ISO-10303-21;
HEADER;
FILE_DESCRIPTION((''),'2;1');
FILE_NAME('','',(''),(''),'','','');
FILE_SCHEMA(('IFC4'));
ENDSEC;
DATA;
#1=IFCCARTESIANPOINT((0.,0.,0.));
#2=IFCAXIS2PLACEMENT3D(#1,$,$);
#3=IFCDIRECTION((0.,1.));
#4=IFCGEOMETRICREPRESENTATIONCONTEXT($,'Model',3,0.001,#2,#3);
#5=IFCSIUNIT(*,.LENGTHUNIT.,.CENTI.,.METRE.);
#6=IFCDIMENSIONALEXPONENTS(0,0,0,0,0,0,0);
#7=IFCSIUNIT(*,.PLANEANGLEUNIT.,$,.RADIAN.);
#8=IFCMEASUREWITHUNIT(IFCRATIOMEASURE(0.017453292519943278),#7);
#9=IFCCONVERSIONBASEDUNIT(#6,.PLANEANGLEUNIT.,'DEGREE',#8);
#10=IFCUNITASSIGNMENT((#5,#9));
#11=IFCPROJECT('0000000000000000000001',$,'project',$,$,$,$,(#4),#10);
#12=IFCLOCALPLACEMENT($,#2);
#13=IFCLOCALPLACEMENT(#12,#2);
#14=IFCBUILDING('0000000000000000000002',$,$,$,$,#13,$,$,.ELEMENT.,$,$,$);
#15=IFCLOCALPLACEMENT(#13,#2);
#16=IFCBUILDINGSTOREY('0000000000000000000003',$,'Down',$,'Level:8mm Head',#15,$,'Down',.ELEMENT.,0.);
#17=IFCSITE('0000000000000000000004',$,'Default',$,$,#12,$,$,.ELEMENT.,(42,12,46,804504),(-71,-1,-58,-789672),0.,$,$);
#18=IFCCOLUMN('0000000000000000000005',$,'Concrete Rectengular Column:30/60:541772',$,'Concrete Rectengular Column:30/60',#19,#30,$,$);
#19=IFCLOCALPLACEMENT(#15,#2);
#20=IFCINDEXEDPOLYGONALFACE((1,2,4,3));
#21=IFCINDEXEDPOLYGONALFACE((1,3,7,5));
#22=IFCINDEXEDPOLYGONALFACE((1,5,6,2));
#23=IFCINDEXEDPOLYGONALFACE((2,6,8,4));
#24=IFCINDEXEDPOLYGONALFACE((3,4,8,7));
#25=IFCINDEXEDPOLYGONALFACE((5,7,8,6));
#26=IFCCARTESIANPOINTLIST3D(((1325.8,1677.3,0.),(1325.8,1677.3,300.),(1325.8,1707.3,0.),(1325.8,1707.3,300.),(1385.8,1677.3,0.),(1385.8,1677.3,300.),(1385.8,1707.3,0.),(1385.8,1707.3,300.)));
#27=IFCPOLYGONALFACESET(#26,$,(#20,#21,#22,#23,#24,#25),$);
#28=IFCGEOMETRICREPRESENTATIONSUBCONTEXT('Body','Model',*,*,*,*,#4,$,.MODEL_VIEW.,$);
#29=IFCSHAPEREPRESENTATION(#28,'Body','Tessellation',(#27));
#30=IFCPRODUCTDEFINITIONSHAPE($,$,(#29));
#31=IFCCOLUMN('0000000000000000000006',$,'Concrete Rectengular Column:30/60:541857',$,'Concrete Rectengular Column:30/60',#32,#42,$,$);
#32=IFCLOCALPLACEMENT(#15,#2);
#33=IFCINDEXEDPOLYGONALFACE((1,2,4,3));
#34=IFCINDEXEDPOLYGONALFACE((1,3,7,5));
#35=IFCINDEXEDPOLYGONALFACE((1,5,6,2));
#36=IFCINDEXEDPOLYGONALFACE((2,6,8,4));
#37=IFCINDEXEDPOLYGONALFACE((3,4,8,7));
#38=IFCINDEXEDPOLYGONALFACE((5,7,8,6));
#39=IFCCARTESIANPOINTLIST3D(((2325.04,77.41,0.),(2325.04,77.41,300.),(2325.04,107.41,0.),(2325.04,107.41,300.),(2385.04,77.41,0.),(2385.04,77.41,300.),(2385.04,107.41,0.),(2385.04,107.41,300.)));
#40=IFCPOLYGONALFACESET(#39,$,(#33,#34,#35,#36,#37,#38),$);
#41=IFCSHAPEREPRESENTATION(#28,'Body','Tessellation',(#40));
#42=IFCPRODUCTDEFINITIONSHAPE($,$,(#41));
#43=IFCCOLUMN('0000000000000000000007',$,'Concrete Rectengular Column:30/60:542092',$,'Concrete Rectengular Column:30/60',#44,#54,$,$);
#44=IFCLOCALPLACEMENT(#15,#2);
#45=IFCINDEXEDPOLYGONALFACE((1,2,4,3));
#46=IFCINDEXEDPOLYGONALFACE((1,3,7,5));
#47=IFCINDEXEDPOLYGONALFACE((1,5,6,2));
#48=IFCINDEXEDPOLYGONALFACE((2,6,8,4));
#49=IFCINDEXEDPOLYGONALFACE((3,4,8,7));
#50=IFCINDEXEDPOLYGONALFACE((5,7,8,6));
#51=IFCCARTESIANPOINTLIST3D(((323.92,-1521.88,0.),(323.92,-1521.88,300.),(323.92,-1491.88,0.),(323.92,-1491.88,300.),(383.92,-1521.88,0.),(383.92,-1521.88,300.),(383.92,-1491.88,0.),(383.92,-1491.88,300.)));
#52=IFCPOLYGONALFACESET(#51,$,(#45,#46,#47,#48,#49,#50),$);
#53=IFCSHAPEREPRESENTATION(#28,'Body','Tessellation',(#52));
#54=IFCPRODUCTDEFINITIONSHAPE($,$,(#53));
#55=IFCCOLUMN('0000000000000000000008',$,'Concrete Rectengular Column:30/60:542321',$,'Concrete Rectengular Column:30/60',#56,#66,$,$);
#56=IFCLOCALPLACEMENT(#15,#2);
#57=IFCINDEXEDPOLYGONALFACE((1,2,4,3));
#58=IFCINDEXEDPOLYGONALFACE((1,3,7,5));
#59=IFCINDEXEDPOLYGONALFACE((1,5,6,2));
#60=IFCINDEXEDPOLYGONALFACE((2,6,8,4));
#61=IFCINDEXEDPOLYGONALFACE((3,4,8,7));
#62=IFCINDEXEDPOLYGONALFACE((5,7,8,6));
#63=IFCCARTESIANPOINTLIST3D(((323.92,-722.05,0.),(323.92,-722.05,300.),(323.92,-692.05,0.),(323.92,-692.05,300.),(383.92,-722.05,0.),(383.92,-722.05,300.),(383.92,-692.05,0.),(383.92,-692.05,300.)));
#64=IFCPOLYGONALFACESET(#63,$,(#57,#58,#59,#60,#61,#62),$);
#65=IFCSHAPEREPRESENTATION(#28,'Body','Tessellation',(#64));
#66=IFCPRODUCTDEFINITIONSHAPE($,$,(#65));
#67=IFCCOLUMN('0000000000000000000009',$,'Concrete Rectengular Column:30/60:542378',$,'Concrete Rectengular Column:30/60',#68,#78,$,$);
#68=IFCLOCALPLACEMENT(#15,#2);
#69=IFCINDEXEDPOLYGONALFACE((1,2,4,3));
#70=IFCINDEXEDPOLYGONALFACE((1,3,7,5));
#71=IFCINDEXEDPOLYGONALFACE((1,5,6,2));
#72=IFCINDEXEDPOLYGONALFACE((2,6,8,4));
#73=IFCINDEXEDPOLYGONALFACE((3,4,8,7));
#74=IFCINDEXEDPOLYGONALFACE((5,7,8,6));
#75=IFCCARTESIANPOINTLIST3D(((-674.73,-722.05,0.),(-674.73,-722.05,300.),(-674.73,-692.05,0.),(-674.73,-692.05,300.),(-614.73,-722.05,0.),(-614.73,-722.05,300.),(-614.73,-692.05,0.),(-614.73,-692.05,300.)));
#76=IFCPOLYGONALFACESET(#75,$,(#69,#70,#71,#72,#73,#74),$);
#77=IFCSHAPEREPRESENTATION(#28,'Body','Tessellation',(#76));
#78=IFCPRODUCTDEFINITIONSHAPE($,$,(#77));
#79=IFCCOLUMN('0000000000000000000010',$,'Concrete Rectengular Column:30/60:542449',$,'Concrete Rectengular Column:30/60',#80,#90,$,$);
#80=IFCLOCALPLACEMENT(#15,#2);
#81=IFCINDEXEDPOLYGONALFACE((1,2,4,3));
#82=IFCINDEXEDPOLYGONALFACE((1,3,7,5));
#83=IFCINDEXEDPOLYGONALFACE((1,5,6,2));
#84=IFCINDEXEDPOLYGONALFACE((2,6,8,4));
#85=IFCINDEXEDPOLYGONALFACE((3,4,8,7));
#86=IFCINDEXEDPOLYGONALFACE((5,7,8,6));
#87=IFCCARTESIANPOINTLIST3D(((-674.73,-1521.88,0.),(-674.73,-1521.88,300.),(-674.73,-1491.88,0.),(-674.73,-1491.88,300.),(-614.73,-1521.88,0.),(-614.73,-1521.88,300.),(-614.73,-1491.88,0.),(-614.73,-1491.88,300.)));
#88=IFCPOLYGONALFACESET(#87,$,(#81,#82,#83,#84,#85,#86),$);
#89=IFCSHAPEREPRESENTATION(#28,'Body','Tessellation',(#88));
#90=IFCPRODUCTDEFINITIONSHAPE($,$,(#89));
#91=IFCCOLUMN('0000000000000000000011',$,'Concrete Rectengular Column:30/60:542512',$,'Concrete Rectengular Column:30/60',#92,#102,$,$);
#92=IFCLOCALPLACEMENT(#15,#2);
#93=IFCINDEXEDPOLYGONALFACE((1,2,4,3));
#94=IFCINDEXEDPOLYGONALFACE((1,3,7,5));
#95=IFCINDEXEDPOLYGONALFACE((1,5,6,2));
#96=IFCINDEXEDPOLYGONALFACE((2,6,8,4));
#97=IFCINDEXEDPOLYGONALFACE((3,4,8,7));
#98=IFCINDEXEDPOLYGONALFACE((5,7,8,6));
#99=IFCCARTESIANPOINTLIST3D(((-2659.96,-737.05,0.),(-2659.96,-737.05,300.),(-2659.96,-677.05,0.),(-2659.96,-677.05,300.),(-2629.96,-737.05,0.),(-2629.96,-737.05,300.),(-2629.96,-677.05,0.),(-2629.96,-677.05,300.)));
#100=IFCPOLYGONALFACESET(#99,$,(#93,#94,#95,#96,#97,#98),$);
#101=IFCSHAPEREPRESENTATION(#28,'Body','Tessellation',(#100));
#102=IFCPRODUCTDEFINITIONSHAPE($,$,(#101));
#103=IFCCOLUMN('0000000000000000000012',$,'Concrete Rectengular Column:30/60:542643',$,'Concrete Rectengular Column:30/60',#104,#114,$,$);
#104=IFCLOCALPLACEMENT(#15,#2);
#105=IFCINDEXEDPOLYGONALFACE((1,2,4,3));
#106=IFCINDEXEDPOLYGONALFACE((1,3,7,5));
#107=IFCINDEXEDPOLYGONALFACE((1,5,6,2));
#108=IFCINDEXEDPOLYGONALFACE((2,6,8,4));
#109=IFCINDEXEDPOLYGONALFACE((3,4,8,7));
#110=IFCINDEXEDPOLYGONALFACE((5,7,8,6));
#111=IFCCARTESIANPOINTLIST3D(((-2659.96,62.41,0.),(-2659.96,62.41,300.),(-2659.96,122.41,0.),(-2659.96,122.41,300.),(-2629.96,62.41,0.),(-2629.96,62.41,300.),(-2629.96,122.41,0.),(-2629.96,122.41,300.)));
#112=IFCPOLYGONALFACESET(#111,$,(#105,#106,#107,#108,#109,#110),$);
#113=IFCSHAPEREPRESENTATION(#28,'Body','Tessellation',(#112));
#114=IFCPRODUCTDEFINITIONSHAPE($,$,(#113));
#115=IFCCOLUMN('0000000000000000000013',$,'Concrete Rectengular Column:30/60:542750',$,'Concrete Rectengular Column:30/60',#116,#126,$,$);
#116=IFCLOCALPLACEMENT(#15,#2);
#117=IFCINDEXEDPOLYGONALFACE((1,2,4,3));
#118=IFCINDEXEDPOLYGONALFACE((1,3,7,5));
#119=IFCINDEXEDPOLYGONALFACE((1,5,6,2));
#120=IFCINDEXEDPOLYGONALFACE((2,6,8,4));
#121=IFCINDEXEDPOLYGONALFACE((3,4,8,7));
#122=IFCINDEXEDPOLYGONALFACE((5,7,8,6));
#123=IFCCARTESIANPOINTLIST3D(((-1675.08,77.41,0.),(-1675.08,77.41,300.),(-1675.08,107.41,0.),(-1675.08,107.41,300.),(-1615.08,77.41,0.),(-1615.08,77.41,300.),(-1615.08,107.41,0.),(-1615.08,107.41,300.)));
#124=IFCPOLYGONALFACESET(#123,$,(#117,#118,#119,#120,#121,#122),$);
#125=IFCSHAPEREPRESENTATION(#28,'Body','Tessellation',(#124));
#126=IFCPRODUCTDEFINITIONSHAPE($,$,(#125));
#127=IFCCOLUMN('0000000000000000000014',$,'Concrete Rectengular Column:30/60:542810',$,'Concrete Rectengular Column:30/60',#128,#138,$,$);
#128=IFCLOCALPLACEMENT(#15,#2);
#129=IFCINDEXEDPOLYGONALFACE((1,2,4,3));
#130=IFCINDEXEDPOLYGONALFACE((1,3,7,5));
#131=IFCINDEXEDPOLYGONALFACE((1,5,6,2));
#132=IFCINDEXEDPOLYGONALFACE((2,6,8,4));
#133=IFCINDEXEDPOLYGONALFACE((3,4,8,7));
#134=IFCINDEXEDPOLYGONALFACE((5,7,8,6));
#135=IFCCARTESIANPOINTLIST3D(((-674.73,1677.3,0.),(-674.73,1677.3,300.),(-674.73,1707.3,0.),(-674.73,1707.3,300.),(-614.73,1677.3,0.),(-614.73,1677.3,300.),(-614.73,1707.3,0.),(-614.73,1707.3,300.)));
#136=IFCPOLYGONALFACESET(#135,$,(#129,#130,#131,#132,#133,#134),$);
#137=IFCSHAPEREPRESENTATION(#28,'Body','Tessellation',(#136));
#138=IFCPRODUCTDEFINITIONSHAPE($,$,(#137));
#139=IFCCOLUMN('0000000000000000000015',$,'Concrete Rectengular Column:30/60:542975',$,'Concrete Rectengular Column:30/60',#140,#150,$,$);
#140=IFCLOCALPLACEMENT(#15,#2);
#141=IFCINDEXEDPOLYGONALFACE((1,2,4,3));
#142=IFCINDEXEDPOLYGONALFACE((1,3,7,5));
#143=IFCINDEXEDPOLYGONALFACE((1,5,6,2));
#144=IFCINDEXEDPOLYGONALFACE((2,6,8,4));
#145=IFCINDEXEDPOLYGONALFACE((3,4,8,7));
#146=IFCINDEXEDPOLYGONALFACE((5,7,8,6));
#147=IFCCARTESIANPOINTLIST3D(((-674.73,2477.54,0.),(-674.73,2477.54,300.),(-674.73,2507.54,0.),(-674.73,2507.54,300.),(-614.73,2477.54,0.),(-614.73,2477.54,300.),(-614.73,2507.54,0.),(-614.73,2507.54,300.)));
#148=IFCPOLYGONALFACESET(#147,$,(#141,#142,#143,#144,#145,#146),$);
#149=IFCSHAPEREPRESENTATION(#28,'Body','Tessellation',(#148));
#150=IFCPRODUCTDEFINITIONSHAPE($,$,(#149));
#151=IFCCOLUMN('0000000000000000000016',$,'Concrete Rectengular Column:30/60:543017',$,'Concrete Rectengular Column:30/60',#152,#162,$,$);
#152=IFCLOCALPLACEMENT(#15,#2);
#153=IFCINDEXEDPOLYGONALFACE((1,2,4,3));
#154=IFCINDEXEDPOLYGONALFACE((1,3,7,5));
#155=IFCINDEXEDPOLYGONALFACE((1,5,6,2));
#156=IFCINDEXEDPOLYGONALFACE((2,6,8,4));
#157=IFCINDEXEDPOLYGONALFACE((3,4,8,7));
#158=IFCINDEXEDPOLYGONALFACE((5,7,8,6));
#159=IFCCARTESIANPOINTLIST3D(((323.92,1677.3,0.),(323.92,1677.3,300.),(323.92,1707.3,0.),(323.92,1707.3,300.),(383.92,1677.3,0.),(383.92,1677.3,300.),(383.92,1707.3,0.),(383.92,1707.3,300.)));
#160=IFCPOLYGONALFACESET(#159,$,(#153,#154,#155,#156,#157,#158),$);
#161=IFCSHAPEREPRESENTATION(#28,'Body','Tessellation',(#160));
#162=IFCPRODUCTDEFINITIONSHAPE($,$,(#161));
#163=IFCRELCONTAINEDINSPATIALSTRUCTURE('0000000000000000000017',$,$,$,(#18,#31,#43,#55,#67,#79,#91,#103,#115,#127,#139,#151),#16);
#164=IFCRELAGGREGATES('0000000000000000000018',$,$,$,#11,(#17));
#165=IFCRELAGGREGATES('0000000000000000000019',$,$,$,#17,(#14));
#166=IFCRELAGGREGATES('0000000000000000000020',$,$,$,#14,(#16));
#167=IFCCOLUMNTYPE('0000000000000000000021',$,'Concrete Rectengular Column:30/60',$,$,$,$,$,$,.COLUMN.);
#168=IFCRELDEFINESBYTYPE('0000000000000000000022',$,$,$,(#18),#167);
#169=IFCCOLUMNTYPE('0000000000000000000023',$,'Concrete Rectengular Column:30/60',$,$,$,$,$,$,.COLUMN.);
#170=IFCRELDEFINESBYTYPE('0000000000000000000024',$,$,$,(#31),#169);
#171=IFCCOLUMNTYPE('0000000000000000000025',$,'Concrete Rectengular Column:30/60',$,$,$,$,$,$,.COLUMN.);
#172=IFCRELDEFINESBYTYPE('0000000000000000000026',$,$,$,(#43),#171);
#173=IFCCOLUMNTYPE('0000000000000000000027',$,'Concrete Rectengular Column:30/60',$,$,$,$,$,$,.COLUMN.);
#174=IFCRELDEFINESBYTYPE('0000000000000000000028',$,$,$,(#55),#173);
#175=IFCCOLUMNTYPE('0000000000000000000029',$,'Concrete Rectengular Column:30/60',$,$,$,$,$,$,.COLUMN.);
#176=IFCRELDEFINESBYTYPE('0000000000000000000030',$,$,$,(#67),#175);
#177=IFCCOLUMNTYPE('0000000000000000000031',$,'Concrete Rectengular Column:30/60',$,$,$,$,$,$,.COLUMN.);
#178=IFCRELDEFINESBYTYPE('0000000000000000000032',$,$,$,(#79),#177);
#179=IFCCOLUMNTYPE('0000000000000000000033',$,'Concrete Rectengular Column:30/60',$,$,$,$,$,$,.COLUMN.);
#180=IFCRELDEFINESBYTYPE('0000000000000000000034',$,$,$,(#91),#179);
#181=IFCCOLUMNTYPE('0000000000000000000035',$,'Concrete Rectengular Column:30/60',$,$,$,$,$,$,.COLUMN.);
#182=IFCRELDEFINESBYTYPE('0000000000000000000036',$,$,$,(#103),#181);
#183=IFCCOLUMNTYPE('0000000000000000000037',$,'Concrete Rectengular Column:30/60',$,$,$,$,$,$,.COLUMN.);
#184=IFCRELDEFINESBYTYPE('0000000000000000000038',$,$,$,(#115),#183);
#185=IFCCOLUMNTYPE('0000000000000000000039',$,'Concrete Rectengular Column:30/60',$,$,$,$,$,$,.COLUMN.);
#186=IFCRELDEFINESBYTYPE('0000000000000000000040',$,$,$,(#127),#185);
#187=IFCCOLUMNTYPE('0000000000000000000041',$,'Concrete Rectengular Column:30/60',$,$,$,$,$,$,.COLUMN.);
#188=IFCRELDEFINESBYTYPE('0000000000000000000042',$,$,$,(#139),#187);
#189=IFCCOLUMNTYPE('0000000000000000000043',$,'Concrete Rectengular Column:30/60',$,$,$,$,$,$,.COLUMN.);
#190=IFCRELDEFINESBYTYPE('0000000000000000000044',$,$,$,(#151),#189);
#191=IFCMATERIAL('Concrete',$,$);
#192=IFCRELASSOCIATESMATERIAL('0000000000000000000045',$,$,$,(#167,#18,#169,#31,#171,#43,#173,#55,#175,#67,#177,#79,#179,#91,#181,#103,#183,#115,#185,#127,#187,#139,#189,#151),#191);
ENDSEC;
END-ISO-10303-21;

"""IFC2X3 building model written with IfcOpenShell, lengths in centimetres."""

from ifc_helpers import new_model, entity, si_unit, converted_unit, direction, frame, frame_2d, origin, origin_2d_with_axis, place, context, subcontext, project, spatial, rectangle, extrude, source, transform, mapped, material, type_object, type_shapes, element, save


model = new_model("IFC2X3")

# Units and contexts
model_context = context("Model", 3, precision=0.001, world=origin(), true_north=direction((0.0, 1.0)))
body_context = subcontext(model_context, "Body", "Model", "MODEL_VIEW")
ifc_project = project(units=[si_unit("LENGTHUNIT", "METRE", prefix="CENTI"), converted_unit("PLANEANGLEUNIT", "DEGREE", entity("IfcRatioMeasure", 0.017453292519943278), si_unit("PLANEANGLEUNIT", "RADIAN"), dimensions=[0, 0, 0, 0, 0, 0, 0])], contexts=[model_context])

# Site, building, storey
site_placement = place(None, origin())
site = spatial("IfcSite", under=ifc_project, at=site_placement, Name="Default", CompositionType="ELEMENT", RefLatitude=(42, 12, 46, 804504), RefLongitude=(-71, -1, -58, -789672), RefElevation=0.0)
building_placement = place(site_placement, origin())
building = spatial("IfcBuilding", under=site, at=building_placement, CompositionType="ELEMENT")
storey_placement = place(building_placement, origin())
storey = spatial("IfcBuildingStorey", under=building, at=storey_placement, Name="Down", ObjectType="Level:8mm Head", LongName="Down", CompositionType="ELEMENT", Elevation=0.0)

# Columns
ifc_material = material(Name="Concrete")
column_type_1 = type_object("IfcColumnType", Name="Concrete Rectengular Column:30/60", PredefinedType="COLUMN", material=ifc_material)
shared_shape_1 = source(origin(), body_context, "Body", "SweptSolid", [
    extrude(rectangle(XDim=30.0, YDim=60.0, at=frame_2d((0.0, 0.0), x_axis=(1.0, 0.0))), frame((1355.8, 1692.3, 0.0), z_axis=(0.0, 0.0, 1.0), x_axis=(0.0, -1.0, 0.0)), (0.0, 0.0, 1.0), 300.0),
])
type_shapes(column_type_1, [shared_shape_1])
column_1_placement = place(storey_placement, origin())
element("IfcColumn", 1, at=column_1_placement, inside=storey, type_object=column_type_1, material=ifc_material, Name="Concrete Rectengular Column:30/60:541772", ObjectType="Concrete Rectengular Column:30/60", context=body_context, shape_type="MappedRepresentation", body=[
    mapped(shared_shape_1, transform((0.0, 0.0, 0.0), scale=1.0)),
])
column_type_2 = type_object("IfcColumnType", Name="Concrete Rectengular Column:30/60", PredefinedType="COLUMN", material=ifc_material)
shared_shape_2 = source(origin(), body_context, "Body", "SweptSolid", [
    extrude(rectangle(XDim=30.0, YDim=60.0, at=origin_2d_with_axis()), frame((2355.04, 92.41, 0.0), z_axis=(0.0, 0.0, 1.0), x_axis=(0.0, -1.0, 0.0)), (0.0, 0.0, 1.0), 300.0),
])
type_shapes(column_type_2, [shared_shape_2])
column_2_placement = place(storey_placement, origin())
element("IfcColumn", 2, at=column_2_placement, inside=storey, type_object=column_type_2, material=ifc_material, Name="Concrete Rectengular Column:30/60:541857", ObjectType="Concrete Rectengular Column:30/60", context=body_context, shape_type="MappedRepresentation", body=[
    mapped(shared_shape_2, transform((0.0, 0.0, 0.0), scale=1.0)),
])
column_type_3 = type_object("IfcColumnType", Name="Concrete Rectengular Column:30/60", PredefinedType="COLUMN", material=ifc_material)
shared_shape_3 = source(origin(), body_context, "Body", "SweptSolid", [
    extrude(rectangle(XDim=30.0, YDim=60.0, at=origin_2d_with_axis()), frame((353.92, -1506.88, 0.0), z_axis=(0.0, 0.0, 1.0), x_axis=(0.0, -1.0, 0.0)), (0.0, 0.0, 1.0), 300.0),
])
type_shapes(column_type_3, [shared_shape_3])
column_3_placement = place(storey_placement, origin())
element("IfcColumn", 3, at=column_3_placement, inside=storey, type_object=column_type_3, material=ifc_material, Name="Concrete Rectengular Column:30/60:542092", ObjectType="Concrete Rectengular Column:30/60", context=body_context, shape_type="MappedRepresentation", body=[
    mapped(shared_shape_3, transform((0.0, 0.0, 0.0), scale=1.0)),
])
column_type_4 = type_object("IfcColumnType", Name="Concrete Rectengular Column:30/60", PredefinedType="COLUMN", material=ifc_material)
shared_shape_4 = source(origin(), body_context, "Body", "SweptSolid", [
    extrude(rectangle(XDim=30.0, YDim=60.0, at=frame_2d((0.0, 0.0), x_axis=(1.0, 0.0))), frame((353.92, -707.05, 0.0), z_axis=(0.0, 0.0, 1.0), x_axis=(0.0, -1.0, 0.0)), (0.0, 0.0, 1.0), 300.0),
])
type_shapes(column_type_4, [shared_shape_4])
column_4_placement = place(storey_placement, origin())
element("IfcColumn", 4, at=column_4_placement, inside=storey, type_object=column_type_4, material=ifc_material, Name="Concrete Rectengular Column:30/60:542321", ObjectType="Concrete Rectengular Column:30/60", context=body_context, shape_type="MappedRepresentation", body=[
    mapped(shared_shape_4, transform((0.0, 0.0, 0.0), scale=1.0)),
])
column_type_5 = type_object("IfcColumnType", Name="Concrete Rectengular Column:30/60", PredefinedType="COLUMN", material=ifc_material)
shared_shape_5 = source(origin(), body_context, "Body", "SweptSolid", [
    extrude(rectangle(XDim=30.0, YDim=60.0, at=frame_2d((0.0, 0.0), x_axis=(1.0, 0.0))), frame((-644.73, -707.05, 0.0), z_axis=(0.0, 0.0, 1.0), x_axis=(0.0, -1.0, 0.0)), (0.0, 0.0, 1.0), 300.0),
])
type_shapes(column_type_5, [shared_shape_5])
column_5_placement = place(storey_placement, origin())
element("IfcColumn", 5, at=column_5_placement, inside=storey, type_object=column_type_5, material=ifc_material, Name="Concrete Rectengular Column:30/60:542378", ObjectType="Concrete Rectengular Column:30/60", context=body_context, shape_type="MappedRepresentation", body=[
    mapped(shared_shape_5, transform((0.0, 0.0, 0.0), scale=1.0)),
])
column_type_6 = type_object("IfcColumnType", Name="Concrete Rectengular Column:30/60", PredefinedType="COLUMN", material=ifc_material)
shared_shape_6 = source(origin(), body_context, "Body", "SweptSolid", [
    extrude(rectangle(XDim=30.0, YDim=60.0, at=origin_2d_with_axis()), frame((-644.73, -1506.88, 0.0), z_axis=(0.0, 0.0, 1.0), x_axis=(0.0, -1.0, 0.0)), (0.0, 0.0, 1.0), 300.0),
])
type_shapes(column_type_6, [shared_shape_6])
column_6_placement = place(storey_placement, origin())
element("IfcColumn", 6, at=column_6_placement, inside=storey, type_object=column_type_6, material=ifc_material, Name="Concrete Rectengular Column:30/60:542449", ObjectType="Concrete Rectengular Column:30/60", context=body_context, shape_type="MappedRepresentation", body=[
    mapped(shared_shape_6, transform((0.0, 0.0, 0.0), scale=1.0)),
])
column_type_7 = type_object("IfcColumnType", Name="Concrete Rectengular Column:30/60", PredefinedType="COLUMN", material=ifc_material)
shared_shape_7 = source(origin(), body_context, "Body", "SweptSolid", [
    extrude(rectangle(XDim=60.0, YDim=30.0, at=origin_2d_with_axis()), frame((-2644.96, -707.05, 0.0), z_axis=(0.0, 0.0, 1.0), x_axis=(0.0, -1.0, 0.0)), (0.0, 0.0, 1.0), 300.0),
])
type_shapes(column_type_7, [shared_shape_7])
column_7_placement = place(storey_placement, origin())
element("IfcColumn", 7, at=column_7_placement, inside=storey, type_object=column_type_7, material=ifc_material, Name="Concrete Rectengular Column:30/60:542512", ObjectType="Concrete Rectengular Column:30/60", context=body_context, shape_type="MappedRepresentation", body=[
    mapped(shared_shape_7, transform((0.0, 0.0, 0.0), scale=1.0)),
])
column_type_8 = type_object("IfcColumnType", Name="Concrete Rectengular Column:30/60", PredefinedType="COLUMN", material=ifc_material)
shared_shape_8 = source(origin(), body_context, "Body", "SweptSolid", [
    extrude(rectangle(XDim=60.0, YDim=30.0, at=frame_2d((0.0, 0.0), x_axis=(1.0, 0.0))), frame((-2644.96, 92.41, 0.0), z_axis=(0.0, 0.0, 1.0), x_axis=(0.0, -1.0, 0.0)), (0.0, 0.0, 1.0), 300.0),
])
type_shapes(column_type_8, [shared_shape_8])
column_8_placement = place(storey_placement, origin())
element("IfcColumn", 8, at=column_8_placement, inside=storey, type_object=column_type_8, material=ifc_material, Name="Concrete Rectengular Column:30/60:542643", ObjectType="Concrete Rectengular Column:30/60", context=body_context, shape_type="MappedRepresentation", body=[
    mapped(shared_shape_8, transform((0.0, 0.0, 0.0), scale=1.0)),
])
column_type_9 = type_object("IfcColumnType", Name="Concrete Rectengular Column:30/60", PredefinedType="COLUMN", material=ifc_material)
shared_shape_9 = source(origin(), body_context, "Body", "SweptSolid", [
    extrude(rectangle(XDim=30.0, YDim=60.0, at=origin_2d_with_axis()), frame((-1645.08, 92.41, 0.0), z_axis=(0.0, 0.0, 1.0), x_axis=(0.0, -1.0, 0.0)), (0.0, 0.0, 1.0), 300.0),
])
type_shapes(column_type_9, [shared_shape_9])
column_9_placement = place(storey_placement, origin())
element("IfcColumn", 9, at=column_9_placement, inside=storey, type_object=column_type_9, material=ifc_material, Name="Concrete Rectengular Column:30/60:542750", ObjectType="Concrete Rectengular Column:30/60", context=body_context, shape_type="MappedRepresentation", body=[
    mapped(shared_shape_9, transform((0.0, 0.0, 0.0), scale=1.0)),
])
column_type_10 = type_object("IfcColumnType", Name="Concrete Rectengular Column:30/60", PredefinedType="COLUMN", material=ifc_material)
shared_shape_10 = source(origin(), body_context, "Body", "SweptSolid", [
    extrude(rectangle(XDim=30.0, YDim=60.0, at=origin_2d_with_axis()), frame((-644.73, 1692.3, 0.0), z_axis=(0.0, 0.0, 1.0), x_axis=(0.0, -1.0, 0.0)), (0.0, 0.0, 1.0), 300.0),
])
type_shapes(column_type_10, [shared_shape_10])
column_10_placement = place(storey_placement, origin())
element("IfcColumn", 10, at=column_10_placement, inside=storey, type_object=column_type_10, material=ifc_material, Name="Concrete Rectengular Column:30/60:542810", ObjectType="Concrete Rectengular Column:30/60", context=body_context, shape_type="MappedRepresentation", body=[
    mapped(shared_shape_10, transform((0.0, 0.0, 0.0), scale=1.0)),
])
column_type_11 = type_object("IfcColumnType", Name="Concrete Rectengular Column:30/60", PredefinedType="COLUMN", material=ifc_material)
shared_shape_11 = source(origin(), body_context, "Body", "SweptSolid", [
    extrude(rectangle(XDim=30.0, YDim=60.0, at=origin_2d_with_axis()), frame((-644.73, 2492.54, 0.0), z_axis=(0.0, 0.0, 1.0), x_axis=(0.0, -1.0, 0.0)), (0.0, 0.0, 1.0), 300.0),
])
type_shapes(column_type_11, [shared_shape_11])
column_11_placement = place(storey_placement, origin())
element("IfcColumn", 11, at=column_11_placement, inside=storey, type_object=column_type_11, material=ifc_material, Name="Concrete Rectengular Column:30/60:542975", ObjectType="Concrete Rectengular Column:30/60", context=body_context, shape_type="MappedRepresentation", body=[
    mapped(shared_shape_11, transform((0.0, 0.0, 0.0), scale=1.0)),
])
column_type_12 = type_object("IfcColumnType", Name="Concrete Rectengular Column:30/60", PredefinedType="COLUMN", material=ifc_material)
shared_shape_12 = source(origin(), body_context, "Body", "SweptSolid", [
    extrude(rectangle(XDim=30.0, YDim=60.0, at=origin_2d_with_axis()), frame((353.92, 1692.3, 0.0), z_axis=(0.0, 0.0, 1.0), x_axis=(0.0, -1.0, 0.0)), (0.0, 0.0, 1.0), 300.0),
])
type_shapes(column_type_12, [shared_shape_12])
column_12_placement = place(storey_placement, origin())
element("IfcColumn", 12, at=column_12_placement, inside=storey, type_object=column_type_12, material=ifc_material, Name="Concrete Rectengular Column:30/60:543017", ObjectType="Concrete Rectengular Column:30/60", context=body_context, shape_type="MappedRepresentation", body=[
    mapped(shared_shape_12, transform((0.0, 0.0, 0.0), scale=1.0)),
])

save(model, "model.ifc")
